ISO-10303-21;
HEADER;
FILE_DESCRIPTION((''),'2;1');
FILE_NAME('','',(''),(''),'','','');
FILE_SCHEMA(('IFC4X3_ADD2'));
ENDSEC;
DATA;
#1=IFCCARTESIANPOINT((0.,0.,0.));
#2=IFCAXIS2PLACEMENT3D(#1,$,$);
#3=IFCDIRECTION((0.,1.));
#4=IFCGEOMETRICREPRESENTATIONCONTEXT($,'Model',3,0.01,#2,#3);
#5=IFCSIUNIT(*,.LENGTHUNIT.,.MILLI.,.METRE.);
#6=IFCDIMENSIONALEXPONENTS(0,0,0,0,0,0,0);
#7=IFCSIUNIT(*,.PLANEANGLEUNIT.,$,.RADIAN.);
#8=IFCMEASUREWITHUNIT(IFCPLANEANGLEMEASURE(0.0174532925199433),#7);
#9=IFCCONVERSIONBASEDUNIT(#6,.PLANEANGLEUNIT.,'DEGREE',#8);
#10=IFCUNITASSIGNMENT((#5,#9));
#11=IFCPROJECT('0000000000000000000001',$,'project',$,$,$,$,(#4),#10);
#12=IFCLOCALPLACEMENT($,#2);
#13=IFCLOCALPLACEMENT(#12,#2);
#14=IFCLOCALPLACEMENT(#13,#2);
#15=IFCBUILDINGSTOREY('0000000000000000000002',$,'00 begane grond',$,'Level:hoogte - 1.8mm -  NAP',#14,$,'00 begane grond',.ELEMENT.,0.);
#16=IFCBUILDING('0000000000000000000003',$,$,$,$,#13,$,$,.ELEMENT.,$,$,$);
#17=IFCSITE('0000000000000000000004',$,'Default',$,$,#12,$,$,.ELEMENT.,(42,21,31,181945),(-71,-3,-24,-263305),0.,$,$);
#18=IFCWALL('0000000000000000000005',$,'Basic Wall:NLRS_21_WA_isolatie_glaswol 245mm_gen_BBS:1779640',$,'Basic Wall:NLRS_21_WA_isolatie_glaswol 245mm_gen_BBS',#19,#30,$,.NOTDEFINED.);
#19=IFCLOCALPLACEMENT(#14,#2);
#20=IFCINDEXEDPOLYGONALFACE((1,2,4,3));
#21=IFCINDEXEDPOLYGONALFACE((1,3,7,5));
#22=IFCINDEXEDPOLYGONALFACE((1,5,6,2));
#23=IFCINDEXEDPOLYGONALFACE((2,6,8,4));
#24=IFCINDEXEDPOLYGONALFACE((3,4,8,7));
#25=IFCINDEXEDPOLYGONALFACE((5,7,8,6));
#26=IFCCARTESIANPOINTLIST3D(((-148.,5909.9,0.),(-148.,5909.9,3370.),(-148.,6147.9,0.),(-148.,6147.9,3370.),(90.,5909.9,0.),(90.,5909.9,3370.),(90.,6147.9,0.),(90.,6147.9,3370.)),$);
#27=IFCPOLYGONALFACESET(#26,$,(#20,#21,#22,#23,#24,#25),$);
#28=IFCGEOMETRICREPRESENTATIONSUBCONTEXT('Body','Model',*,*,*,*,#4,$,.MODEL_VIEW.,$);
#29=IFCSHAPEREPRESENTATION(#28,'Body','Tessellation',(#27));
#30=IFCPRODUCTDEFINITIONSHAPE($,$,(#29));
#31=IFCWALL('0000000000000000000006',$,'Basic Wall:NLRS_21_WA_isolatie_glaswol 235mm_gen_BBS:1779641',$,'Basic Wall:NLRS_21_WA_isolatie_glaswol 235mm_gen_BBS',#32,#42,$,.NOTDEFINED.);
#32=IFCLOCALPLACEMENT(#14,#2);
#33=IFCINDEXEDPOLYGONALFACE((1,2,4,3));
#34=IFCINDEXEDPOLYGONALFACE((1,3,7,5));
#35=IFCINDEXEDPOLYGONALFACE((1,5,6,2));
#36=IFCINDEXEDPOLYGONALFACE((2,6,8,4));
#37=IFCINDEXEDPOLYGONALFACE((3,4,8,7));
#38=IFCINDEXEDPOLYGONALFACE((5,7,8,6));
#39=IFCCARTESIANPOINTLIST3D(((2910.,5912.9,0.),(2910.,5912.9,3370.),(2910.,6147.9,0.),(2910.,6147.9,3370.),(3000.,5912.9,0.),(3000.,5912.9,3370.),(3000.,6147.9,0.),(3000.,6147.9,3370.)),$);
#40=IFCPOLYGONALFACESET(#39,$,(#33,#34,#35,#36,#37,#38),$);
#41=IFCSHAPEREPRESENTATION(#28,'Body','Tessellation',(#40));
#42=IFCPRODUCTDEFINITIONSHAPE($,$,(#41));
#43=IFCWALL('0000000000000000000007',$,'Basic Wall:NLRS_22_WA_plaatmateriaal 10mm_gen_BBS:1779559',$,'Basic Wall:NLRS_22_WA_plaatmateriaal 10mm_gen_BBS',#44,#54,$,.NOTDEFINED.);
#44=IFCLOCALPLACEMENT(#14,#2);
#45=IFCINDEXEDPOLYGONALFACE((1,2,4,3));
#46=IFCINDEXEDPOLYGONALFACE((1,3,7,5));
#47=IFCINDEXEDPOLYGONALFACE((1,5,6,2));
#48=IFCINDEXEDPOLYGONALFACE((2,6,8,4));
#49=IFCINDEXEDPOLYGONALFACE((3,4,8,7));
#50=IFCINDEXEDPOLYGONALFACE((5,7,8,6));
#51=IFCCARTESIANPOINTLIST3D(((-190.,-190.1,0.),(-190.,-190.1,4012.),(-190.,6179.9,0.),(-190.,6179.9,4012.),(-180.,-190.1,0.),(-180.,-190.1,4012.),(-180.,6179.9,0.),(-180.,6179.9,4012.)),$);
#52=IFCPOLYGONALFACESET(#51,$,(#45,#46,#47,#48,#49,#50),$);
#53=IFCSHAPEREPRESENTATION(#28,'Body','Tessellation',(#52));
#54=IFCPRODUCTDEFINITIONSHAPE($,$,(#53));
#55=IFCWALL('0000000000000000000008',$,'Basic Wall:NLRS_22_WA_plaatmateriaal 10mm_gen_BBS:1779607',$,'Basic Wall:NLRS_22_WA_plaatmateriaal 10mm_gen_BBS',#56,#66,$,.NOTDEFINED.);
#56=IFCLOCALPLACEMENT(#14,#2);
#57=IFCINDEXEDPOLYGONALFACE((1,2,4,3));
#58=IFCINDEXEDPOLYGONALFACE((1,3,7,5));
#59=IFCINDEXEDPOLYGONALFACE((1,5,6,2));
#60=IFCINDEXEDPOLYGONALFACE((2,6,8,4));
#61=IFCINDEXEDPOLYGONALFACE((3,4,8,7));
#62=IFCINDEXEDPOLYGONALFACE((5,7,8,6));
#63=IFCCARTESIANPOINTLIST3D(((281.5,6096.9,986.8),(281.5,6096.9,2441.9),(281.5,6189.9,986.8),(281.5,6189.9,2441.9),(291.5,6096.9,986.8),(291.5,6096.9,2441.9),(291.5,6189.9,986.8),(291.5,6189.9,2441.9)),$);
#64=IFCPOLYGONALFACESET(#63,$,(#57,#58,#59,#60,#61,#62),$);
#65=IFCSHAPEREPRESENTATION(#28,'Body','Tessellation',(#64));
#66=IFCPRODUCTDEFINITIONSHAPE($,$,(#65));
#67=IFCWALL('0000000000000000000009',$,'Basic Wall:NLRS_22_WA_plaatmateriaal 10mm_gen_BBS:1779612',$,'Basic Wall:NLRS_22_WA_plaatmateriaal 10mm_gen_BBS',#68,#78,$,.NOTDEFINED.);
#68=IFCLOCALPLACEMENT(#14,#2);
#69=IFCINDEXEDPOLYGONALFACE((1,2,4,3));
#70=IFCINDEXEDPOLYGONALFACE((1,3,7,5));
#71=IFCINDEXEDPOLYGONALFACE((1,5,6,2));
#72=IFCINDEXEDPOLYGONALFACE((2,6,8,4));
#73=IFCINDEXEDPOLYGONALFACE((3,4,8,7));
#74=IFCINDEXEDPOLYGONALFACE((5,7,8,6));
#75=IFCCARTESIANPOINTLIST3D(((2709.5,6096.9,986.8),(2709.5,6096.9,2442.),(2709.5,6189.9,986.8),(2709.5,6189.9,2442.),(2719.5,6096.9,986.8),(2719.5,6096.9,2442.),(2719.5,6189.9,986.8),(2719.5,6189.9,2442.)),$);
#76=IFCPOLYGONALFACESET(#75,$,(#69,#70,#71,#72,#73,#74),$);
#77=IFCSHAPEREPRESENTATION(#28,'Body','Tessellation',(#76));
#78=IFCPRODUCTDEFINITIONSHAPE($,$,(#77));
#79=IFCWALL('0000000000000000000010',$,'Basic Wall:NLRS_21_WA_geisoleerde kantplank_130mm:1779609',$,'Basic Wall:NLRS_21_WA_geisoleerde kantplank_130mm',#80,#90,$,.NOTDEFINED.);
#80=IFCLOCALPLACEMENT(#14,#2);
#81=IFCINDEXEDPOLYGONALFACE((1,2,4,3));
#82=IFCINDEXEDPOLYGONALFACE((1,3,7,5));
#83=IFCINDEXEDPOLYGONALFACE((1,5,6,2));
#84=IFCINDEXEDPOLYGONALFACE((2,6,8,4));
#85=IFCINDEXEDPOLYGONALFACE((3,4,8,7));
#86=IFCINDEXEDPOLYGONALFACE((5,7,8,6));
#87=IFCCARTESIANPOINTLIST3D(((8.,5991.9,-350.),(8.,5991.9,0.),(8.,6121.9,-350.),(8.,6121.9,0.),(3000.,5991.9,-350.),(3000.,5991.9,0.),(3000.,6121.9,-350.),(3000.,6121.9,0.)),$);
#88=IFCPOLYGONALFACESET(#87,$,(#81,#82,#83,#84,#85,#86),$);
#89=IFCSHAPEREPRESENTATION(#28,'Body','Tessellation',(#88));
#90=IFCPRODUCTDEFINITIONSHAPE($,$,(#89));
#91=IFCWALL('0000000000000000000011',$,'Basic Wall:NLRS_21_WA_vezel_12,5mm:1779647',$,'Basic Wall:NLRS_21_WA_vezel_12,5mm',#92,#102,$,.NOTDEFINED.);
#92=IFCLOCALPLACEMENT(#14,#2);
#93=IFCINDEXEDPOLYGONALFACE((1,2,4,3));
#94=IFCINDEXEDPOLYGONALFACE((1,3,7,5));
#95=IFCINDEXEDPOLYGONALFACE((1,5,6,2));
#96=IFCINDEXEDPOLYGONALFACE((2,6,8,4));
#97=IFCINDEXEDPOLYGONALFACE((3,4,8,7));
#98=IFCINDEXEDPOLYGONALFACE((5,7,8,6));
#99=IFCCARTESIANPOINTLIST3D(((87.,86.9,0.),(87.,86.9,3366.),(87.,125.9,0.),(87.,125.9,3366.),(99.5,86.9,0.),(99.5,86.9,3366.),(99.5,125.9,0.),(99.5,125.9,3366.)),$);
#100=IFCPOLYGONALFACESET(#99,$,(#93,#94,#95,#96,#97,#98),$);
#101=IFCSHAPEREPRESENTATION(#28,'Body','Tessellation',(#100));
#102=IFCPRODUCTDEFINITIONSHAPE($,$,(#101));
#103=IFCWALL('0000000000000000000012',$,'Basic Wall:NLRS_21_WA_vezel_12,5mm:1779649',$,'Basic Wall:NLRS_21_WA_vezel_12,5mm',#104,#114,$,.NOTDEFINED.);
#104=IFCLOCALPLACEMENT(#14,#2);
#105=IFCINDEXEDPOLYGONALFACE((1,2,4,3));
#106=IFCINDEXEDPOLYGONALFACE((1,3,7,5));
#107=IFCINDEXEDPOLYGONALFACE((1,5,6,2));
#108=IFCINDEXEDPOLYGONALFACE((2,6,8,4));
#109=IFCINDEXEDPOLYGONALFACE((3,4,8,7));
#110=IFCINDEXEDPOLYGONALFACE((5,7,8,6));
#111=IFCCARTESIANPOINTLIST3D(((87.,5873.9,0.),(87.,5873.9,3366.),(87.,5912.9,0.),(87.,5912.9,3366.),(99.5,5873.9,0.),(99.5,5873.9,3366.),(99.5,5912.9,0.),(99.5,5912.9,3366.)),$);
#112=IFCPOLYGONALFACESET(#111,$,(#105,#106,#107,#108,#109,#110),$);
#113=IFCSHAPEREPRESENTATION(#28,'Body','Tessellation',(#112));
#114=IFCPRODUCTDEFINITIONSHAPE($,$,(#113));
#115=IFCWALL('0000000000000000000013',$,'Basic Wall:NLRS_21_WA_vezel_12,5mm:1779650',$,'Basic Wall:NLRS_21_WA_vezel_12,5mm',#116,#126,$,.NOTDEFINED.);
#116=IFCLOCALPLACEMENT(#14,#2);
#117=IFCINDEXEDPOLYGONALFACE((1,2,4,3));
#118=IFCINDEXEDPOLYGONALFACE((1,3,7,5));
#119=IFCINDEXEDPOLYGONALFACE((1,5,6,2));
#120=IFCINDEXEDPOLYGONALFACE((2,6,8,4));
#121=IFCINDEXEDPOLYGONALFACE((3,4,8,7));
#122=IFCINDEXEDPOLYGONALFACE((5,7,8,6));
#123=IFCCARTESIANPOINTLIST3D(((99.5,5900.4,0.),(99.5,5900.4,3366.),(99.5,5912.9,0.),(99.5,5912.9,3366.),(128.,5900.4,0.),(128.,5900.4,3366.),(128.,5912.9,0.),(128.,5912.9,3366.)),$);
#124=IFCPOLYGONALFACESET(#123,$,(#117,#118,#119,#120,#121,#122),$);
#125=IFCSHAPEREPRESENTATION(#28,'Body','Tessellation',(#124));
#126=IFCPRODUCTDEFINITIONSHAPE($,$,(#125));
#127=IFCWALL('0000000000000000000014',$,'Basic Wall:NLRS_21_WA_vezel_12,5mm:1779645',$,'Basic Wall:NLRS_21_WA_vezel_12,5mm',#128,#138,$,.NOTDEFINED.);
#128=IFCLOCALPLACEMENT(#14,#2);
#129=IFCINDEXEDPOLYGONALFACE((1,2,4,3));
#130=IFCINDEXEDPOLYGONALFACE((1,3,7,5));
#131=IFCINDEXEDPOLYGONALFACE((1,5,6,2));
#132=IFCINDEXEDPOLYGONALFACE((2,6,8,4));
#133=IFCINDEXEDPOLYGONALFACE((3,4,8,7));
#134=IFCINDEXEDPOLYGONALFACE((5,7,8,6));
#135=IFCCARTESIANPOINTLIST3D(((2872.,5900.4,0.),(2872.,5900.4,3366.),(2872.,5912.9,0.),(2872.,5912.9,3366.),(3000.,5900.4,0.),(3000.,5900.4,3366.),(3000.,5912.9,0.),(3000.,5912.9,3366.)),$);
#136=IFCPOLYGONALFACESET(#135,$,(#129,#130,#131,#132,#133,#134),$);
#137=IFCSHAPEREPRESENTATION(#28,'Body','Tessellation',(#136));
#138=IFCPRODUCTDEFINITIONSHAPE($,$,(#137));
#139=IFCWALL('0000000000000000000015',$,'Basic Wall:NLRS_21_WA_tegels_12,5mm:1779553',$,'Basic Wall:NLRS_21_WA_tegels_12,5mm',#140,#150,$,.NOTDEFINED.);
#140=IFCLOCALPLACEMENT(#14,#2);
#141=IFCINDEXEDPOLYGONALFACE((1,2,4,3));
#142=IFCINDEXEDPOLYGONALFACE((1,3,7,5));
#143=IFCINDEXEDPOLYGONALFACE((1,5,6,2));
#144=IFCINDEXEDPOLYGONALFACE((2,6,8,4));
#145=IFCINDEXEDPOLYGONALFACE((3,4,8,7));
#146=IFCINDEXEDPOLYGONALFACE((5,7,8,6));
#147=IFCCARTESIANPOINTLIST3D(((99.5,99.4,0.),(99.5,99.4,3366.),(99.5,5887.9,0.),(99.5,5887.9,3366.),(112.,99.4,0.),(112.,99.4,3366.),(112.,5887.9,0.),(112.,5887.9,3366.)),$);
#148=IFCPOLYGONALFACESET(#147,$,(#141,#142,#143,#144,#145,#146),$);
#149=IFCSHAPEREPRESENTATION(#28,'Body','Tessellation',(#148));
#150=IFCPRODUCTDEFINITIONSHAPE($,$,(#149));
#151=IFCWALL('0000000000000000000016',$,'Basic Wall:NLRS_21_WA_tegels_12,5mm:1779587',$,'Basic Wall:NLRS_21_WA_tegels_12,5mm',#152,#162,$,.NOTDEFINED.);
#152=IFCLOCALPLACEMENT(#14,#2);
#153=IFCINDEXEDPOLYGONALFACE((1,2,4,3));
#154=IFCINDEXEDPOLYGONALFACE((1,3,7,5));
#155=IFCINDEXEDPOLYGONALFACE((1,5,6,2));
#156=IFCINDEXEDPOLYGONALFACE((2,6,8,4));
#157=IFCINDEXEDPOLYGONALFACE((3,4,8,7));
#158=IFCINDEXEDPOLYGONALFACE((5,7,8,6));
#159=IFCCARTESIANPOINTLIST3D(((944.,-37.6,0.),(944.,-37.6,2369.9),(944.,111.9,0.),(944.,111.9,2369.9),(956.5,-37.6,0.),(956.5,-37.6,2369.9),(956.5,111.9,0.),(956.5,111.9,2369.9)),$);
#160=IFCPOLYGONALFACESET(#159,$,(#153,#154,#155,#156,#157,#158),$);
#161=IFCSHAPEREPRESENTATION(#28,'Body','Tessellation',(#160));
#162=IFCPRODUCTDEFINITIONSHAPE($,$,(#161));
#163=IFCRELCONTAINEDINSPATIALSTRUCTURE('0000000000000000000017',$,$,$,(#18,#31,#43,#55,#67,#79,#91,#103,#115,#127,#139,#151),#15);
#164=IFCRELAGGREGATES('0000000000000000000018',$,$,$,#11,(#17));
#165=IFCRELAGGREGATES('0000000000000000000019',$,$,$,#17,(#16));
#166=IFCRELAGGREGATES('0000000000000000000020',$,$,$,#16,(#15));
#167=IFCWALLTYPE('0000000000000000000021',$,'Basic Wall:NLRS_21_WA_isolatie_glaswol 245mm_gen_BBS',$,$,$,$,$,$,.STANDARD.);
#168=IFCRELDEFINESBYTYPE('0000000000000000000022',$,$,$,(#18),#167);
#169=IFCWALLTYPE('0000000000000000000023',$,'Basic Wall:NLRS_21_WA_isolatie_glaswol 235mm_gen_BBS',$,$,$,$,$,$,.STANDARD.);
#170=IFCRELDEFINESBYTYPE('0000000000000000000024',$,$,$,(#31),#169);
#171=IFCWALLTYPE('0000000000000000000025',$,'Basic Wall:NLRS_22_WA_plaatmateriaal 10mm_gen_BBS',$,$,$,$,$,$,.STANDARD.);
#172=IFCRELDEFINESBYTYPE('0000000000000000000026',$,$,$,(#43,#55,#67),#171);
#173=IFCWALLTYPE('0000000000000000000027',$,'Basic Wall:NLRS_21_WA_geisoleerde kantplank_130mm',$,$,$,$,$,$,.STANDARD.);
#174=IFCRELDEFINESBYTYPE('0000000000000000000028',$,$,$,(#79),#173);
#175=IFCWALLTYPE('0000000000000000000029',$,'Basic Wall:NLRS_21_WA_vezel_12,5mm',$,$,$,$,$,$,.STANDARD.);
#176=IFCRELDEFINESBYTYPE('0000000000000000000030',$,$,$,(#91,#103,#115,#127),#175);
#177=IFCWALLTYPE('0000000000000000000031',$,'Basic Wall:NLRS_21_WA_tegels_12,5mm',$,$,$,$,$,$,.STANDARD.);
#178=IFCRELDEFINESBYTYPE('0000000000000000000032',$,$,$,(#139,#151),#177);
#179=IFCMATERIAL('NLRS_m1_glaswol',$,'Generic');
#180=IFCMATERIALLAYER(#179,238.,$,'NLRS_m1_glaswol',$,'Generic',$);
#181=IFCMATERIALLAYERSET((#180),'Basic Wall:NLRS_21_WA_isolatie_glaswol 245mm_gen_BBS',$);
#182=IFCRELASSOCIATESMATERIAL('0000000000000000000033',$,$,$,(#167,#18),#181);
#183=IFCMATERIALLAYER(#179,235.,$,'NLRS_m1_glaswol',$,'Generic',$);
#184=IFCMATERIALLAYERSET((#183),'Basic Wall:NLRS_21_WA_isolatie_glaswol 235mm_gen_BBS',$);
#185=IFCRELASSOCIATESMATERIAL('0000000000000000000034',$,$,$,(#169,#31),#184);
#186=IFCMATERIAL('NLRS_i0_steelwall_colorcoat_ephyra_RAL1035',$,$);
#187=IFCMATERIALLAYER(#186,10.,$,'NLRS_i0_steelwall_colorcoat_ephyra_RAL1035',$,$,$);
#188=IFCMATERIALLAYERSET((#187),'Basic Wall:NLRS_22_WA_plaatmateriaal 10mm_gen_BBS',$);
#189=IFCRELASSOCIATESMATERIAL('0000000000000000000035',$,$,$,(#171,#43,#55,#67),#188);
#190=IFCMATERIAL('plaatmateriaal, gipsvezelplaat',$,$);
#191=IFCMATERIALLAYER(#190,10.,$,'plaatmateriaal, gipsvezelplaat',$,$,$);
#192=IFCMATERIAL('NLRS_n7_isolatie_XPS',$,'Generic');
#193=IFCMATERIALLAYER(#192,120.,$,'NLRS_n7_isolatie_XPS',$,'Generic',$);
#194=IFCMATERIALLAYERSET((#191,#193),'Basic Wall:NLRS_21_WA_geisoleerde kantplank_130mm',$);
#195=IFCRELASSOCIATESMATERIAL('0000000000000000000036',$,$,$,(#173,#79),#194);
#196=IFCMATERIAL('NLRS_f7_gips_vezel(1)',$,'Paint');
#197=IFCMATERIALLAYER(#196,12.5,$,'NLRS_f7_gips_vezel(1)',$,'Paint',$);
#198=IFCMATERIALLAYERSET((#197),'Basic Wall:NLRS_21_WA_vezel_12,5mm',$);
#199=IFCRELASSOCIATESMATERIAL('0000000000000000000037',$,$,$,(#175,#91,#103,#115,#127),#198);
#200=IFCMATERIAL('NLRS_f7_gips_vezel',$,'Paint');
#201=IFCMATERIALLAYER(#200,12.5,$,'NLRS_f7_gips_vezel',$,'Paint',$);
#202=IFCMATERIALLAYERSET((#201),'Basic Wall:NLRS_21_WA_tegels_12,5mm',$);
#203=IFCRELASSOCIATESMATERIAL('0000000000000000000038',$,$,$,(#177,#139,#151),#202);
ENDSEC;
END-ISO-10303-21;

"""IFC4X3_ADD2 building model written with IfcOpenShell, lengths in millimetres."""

from ifc_helpers import new_model, entity, si_unit, converted_unit, direction, frame, frame_2d, origin, place, context, subcontext, project, spatial, rectangle, extrude, material, layer, layer_set, layer_usage, type_object, element, save


model = new_model("IFC4X3_ADD2")

# Units and contexts
model_context = context("Model", 3, precision=0.01, world=origin(), true_north=direction((0.0, 1.0)))
body_context = subcontext(model_context, "Body", "Model", "MODEL_VIEW")
ifc_project = project(units=[si_unit("LENGTHUNIT", "METRE", prefix="MILLI"), converted_unit("PLANEANGLEUNIT", "DEGREE", entity("IfcPlaneAngleMeasure", 0.0174532925199433), si_unit("PLANEANGLEUNIT", "RADIAN"), dimensions=[0, 0, 0, 0, 0, 0, 0])], contexts=[model_context])

# Site, building, storey
site_placement = place(None, origin())
site = spatial("IfcSite", under=ifc_project, at=site_placement, Name="Default", CompositionType="ELEMENT", RefLatitude=(42, 21, 31, 181945), RefLongitude=(-71, -3, -24, -263305), RefElevation=0.0)
building_placement = place(site_placement, origin())
building = spatial("IfcBuilding", under=site, at=building_placement, CompositionType="ELEMENT")
storey_placement = place(building_placement, origin())
storey = spatial("IfcBuildingStorey", under=building, at=storey_placement, Name="00 begane grond", ObjectType="Level:hoogte - 1.8mm -  NAP", LongName="00 begane grond", CompositionType="ELEMENT", Elevation=0.0)

# Walls
ifc_material_1 = material(Name="NLRS_m1_glaswol", Category="Generic")
ifc_layer_1 = layer(ifc_material_1, 238.0, Name="NLRS_m1_glaswol", Category="Generic")
ifc_layer_set_1 = layer_set([ifc_layer_1], Name="Basic Wall:NLRS_21_WA_isolatie_glaswol 245mm_gen_BBS")
ifc_layer_usage_1 = layer_usage(ifc_layer_set_1, "AXIS2", "NEGATIVE", 119.0)
wall_type_1 = type_object("IfcWallType", Name="Basic Wall:NLRS_21_WA_isolatie_glaswol 245mm_gen_BBS", PredefinedType="STANDARD", material=ifc_layer_set_1)
wall_1_placement = place(storey_placement, frame((-29.0, 6147.9, 0.0), z_axis=(0.0, 0.0, 1.0), x_axis=(0.0, -1.0, 0.0)))
element("IfcWall", 1, at=wall_1_placement, inside=storey, type_object=wall_type_1, material=ifc_layer_usage_1, Name="Basic Wall:NLRS_21_WA_isolatie_glaswol 245mm_gen_BBS:1779640", ObjectType="Basic Wall:NLRS_21_WA_isolatie_glaswol 245mm_gen_BBS", PredefinedType="NOTDEFINED", context=body_context, shape_type="SweptSolid", body=[
    extrude(rectangle(XDim=238.0, YDim=238.0, at=frame_2d((119.0, 0.0), x_axis=(-1.0, 0.0))), origin(), (0.0, 0.0, 1.0), 3370.0),
])
ifc_layer_2 = layer(ifc_material_1, 235.0, Name="NLRS_m1_glaswol", Category="Generic")
ifc_layer_set_2 = layer_set([ifc_layer_2], Name="Basic Wall:NLRS_21_WA_isolatie_glaswol 235mm_gen_BBS")
ifc_layer_usage_2 = layer_usage(ifc_layer_set_2, "AXIS2", "NEGATIVE", 117.5)
wall_type_2 = type_object("IfcWallType", Name="Basic Wall:NLRS_21_WA_isolatie_glaswol 235mm_gen_BBS", PredefinedType="STANDARD", material=ifc_layer_set_2)
wall_2_placement = place(storey_placement, frame((2910.0, 6030.4, 0.0)))
element("IfcWall", 2, at=wall_2_placement, inside=storey, type_object=wall_type_2, material=ifc_layer_usage_2, Name="Basic Wall:NLRS_21_WA_isolatie_glaswol 235mm_gen_BBS:1779641", ObjectType="Basic Wall:NLRS_21_WA_isolatie_glaswol 235mm_gen_BBS", PredefinedType="NOTDEFINED", context=body_context, shape_type="SweptSolid", body=[
    extrude(rectangle(XDim=90.0, YDim=235.0, at=frame_2d((45.0, 0.0), x_axis=(-1.0, 0.0))), origin(), (0.0, 0.0, 1.0), 3370.0),
])
ifc_material_2 = material(Name="NLRS_i0_steelwall_colorcoat_ephyra_RAL1035")
ifc_layer_3 = layer(ifc_material_2, 10.0, Name="NLRS_i0_steelwall_colorcoat_ephyra_RAL1035")
ifc_layer_set_3 = layer_set([ifc_layer_3], Name="Basic Wall:NLRS_22_WA_plaatmateriaal 10mm_gen_BBS")
ifc_layer_usage_3 = layer_usage(ifc_layer_set_3, "AXIS2", "POSITIVE", -5.0)
wall_type_3 = type_object("IfcWallType", Name="Basic Wall:NLRS_22_WA_plaatmateriaal 10mm_gen_BBS", PredefinedType="STANDARD", material=ifc_layer_set_3)
wall_3_placement = place(storey_placement, frame((-185.0, 6179.9, 0.0), z_axis=(0.0, 0.0, 1.0), x_axis=(0.0, -1.0, 0.0)))
element("IfcWall", 3, at=wall_3_placement, inside=storey, type_object=wall_type_3, material=ifc_layer_usage_3, Name="Basic Wall:NLRS_22_WA_plaatmateriaal 10mm_gen_BBS:1779559", ObjectType="Basic Wall:NLRS_22_WA_plaatmateriaal 10mm_gen_BBS", PredefinedType="NOTDEFINED", context=body_context, shape_type="SweptSolid", body=[
    extrude(rectangle(XDim=6370.0, YDim=10.0, at=frame_2d((3185.0, 0.0), x_axis=(-1.0, 0.0))), origin(), (0.0, 0.0, 1.0), 4012.0),
])
ifc_layer_usage_4 = layer_usage(ifc_layer_set_3, "AXIS2", "POSITIVE", -5.0)
wall_4_placement = place(storey_placement, frame((286.5, 6096.9, 986.8), z_axis=(0.0, 0.0, 1.0), x_axis=(0.0, 1.0, 0.0)))
element("IfcWall", 4, at=wall_4_placement, inside=storey, type_object=wall_type_3, material=ifc_layer_usage_4, Name="Basic Wall:NLRS_22_WA_plaatmateriaal 10mm_gen_BBS:1779607", ObjectType="Basic Wall:NLRS_22_WA_plaatmateriaal 10mm_gen_BBS", PredefinedType="NOTDEFINED", context=body_context, shape_type="SweptSolid", body=[
    extrude(rectangle(XDim=93.0, YDim=10.0, at=frame_2d((46.5, 0.0), x_axis=(-1.0, 0.0))), origin(), (0.0, 0.0, 1.0), 1455.1),
])
ifc_layer_usage_5 = layer_usage(ifc_layer_set_3, "AXIS2", "NEGATIVE", 5.0)
wall_5_placement = place(storey_placement, frame((2714.5, 6096.9, 986.8), z_axis=(0.0, 0.0, 1.0), x_axis=(0.0, 1.0, 0.0)))
element("IfcWall", 5, at=wall_5_placement, inside=storey, type_object=wall_type_3, material=ifc_layer_usage_5, Name="Basic Wall:NLRS_22_WA_plaatmateriaal 10mm_gen_BBS:1779612", ObjectType="Basic Wall:NLRS_22_WA_plaatmateriaal 10mm_gen_BBS", PredefinedType="NOTDEFINED", context=body_context, shape_type="SweptSolid", body=[
    extrude(rectangle(XDim=93.0, YDim=10.0, at=frame_2d((46.5, 0.0), x_axis=(-1.0, 0.0))), origin(), (0.0, 0.0, 1.0), 1455.2),
])
ifc_material_3 = material(Name="plaatmateriaal, gipsvezelplaat")
ifc_layer_4 = layer(ifc_material_3, 10.0, Name="plaatmateriaal, gipsvezelplaat")
ifc_material_4 = material(Name="NLRS_n7_isolatie_XPS", Category="Generic")
ifc_layer_5 = layer(ifc_material_4, 120.0, Name="NLRS_n7_isolatie_XPS", Category="Generic")
ifc_layer_set_4 = layer_set([ifc_layer_4, ifc_layer_5], Name="Basic Wall:NLRS_21_WA_geisoleerde kantplank_130mm")
ifc_layer_usage_6 = layer_usage(ifc_layer_set_4, "AXIS2", "NEGATIVE", 65.0)
wall_type_4 = type_object("IfcWallType", Name="Basic Wall:NLRS_21_WA_geisoleerde kantplank_130mm", PredefinedType="STANDARD", material=ifc_layer_set_4)
wall_6_placement = place(storey_placement, frame((8.0, 6056.9, -350.0)))
element("IfcWall", 6, at=wall_6_placement, inside=storey, type_object=wall_type_4, material=ifc_layer_usage_6, Name="Basic Wall:NLRS_21_WA_geisoleerde kantplank_130mm:1779609", ObjectType="Basic Wall:NLRS_21_WA_geisoleerde kantplank_130mm", PredefinedType="NOTDEFINED", context=body_context, shape_type="SweptSolid", body=[
    extrude(rectangle(XDim=2992.0, YDim=130.0, at=frame_2d((1496.0, 0.0), x_axis=(-1.0, 0.0))), origin(), (0.0, 0.0, 1.0), 350.0),
])
ifc_material_5 = material(Name="NLRS_f7_gips_vezel(1)", Category="Paint")
ifc_layer_6 = layer(ifc_material_5, 12.5, Name="NLRS_f7_gips_vezel(1)", Category="Paint")
ifc_layer_set_5 = layer_set([ifc_layer_6], Name="Basic Wall:NLRS_21_WA_vezel_12,5mm")
ifc_layer_usage_7 = layer_usage(ifc_layer_set_5, "AXIS2", "NEGATIVE", 6.2)
wall_type_5 = type_object("IfcWallType", Name="Basic Wall:NLRS_21_WA_vezel_12,5mm", PredefinedType="STANDARD", material=ifc_layer_set_5)
wall_7_placement = place(storey_placement, frame((93.2, 125.9, 0.0), z_axis=(0.0, 0.0, 1.0), x_axis=(0.0, -1.0, 0.0)))
element("IfcWall", 7, at=wall_7_placement, inside=storey, type_object=wall_type_5, material=ifc_layer_usage_7, Name="Basic Wall:NLRS_21_WA_vezel_12,5mm:1779647", ObjectType="Basic Wall:NLRS_21_WA_vezel_12,5mm", PredefinedType="NOTDEFINED", context=body_context, shape_type="SweptSolid", body=[
    extrude(rectangle(XDim=39.0, YDim=12.5, at=frame_2d((19.5, 0.0), x_axis=(-1.0, 0.0))), origin(), (0.0, 0.0, 1.0), 3366.0),
])
ifc_layer_usage_8 = layer_usage(ifc_layer_set_5, "AXIS2", "POSITIVE", -6.2)
wall_8_placement = place(storey_placement, frame((93.2, 5873.9, 0.0), z_axis=(0.0, 0.0, 1.0), x_axis=(0.0, 1.0, 0.0)))
element("IfcWall", 8, at=wall_8_placement, inside=storey, type_object=wall_type_5, material=ifc_layer_usage_8, Name="Basic Wall:NLRS_21_WA_vezel_12,5mm:1779649", ObjectType="Basic Wall:NLRS_21_WA_vezel_12,5mm", PredefinedType="NOTDEFINED", context=body_context, shape_type="SweptSolid", body=[
    extrude(rectangle(XDim=39.0, YDim=12.5, at=frame_2d((19.5, 0.0), x_axis=(-1.0, 0.0))), origin(), (0.0, 0.0, 1.0), 3366.0),
])
ifc_layer_usage_9 = layer_usage(ifc_layer_set_5, "AXIS2", "POSITIVE", -6.2)
wall_9_placement = place(storey_placement, frame((99.5, 5906.7, 0.0)))
element("IfcWall", 9, at=wall_9_placement, inside=storey, type_object=wall_type_5, material=ifc_layer_usage_9, Name="Basic Wall:NLRS_21_WA_vezel_12,5mm:1779650", ObjectType="Basic Wall:NLRS_21_WA_vezel_12,5mm", PredefinedType="NOTDEFINED", context=body_context, shape_type="SweptSolid", body=[
    extrude(rectangle(XDim=28.5, YDim=12.5, at=frame_2d((14.2, 0.0), x_axis=(-1.0, 0.0))), origin(), (0.0, 0.0, 1.0), 3366.0),
])
ifc_layer_usage_10 = layer_usage(ifc_layer_set_5, "AXIS2", "NEGATIVE", 6.2)
wall_10_placement = place(storey_placement, frame((2872.0, 5906.7, 0.0)))
element("IfcWall", 10, at=wall_10_placement, inside=storey, type_object=wall_type_5, material=ifc_layer_usage_10, Name="Basic Wall:NLRS_21_WA_vezel_12,5mm:1779645", ObjectType="Basic Wall:NLRS_21_WA_vezel_12,5mm", PredefinedType="NOTDEFINED", context=body_context, shape_type="SweptSolid", body=[
    extrude(rectangle(XDim=128.0, YDim=12.5, at=frame_2d((64.0, 0.0), x_axis=(-1.0, 0.0))), origin(), (0.0, 0.0, 1.0), 3366.0),
])
ifc_material_6 = material(Name="NLRS_f7_gips_vezel", Category="Paint")
ifc_layer_7 = layer(ifc_material_6, 12.5, Name="NLRS_f7_gips_vezel", Category="Paint")
ifc_layer_set_6 = layer_set([ifc_layer_7], Name="Basic Wall:NLRS_21_WA_tegels_12,5mm")
ifc_layer_usage_11 = layer_usage(ifc_layer_set_6, "AXIS2", "NEGATIVE", 6.2)
wall_type_6 = type_object("IfcWallType", Name="Basic Wall:NLRS_21_WA_tegels_12,5mm", PredefinedType="STANDARD", material=ifc_layer_set_6)
wall_11_placement = place(storey_placement, frame((105.7, 5887.9, 0.0), z_axis=(0.0, 0.0, 1.0), x_axis=(0.0, -1.0, 0.0)))
element("IfcWall", 11, at=wall_11_placement, inside=storey, type_object=wall_type_6, material=ifc_layer_usage_11, Name="Basic Wall:NLRS_21_WA_tegels_12,5mm:1779553", ObjectType="Basic Wall:NLRS_21_WA_tegels_12,5mm", PredefinedType="NOTDEFINED", context=body_context, shape_type="SweptSolid", body=[
    extrude(rectangle(XDim=5788.5, YDim=12.5, at=frame_2d((2894.3, 0.0), x_axis=(-1.0, 0.0))), origin(), (0.0, 0.0, 1.0), 3366.0),
])
ifc_layer_usage_12 = layer_usage(ifc_layer_set_6, "AXIS2", "NEGATIVE", 6.2)
wall_12_placement = place(storey_placement, frame((950.2, 111.9, 0.0), z_axis=(0.0, 0.0, 1.0), x_axis=(0.0, -1.0, 0.0)))
element("IfcWall", 12, at=wall_12_placement, inside=storey, type_object=wall_type_6, material=ifc_layer_usage_12, Name="Basic Wall:NLRS_21_WA_tegels_12,5mm:1779587", ObjectType="Basic Wall:NLRS_21_WA_tegels_12,5mm", PredefinedType="NOTDEFINED", context=body_context, shape_type="SweptSolid", body=[
    extrude(rectangle(XDim=149.5, YDim=12.5, at=frame_2d((74.8, 0.0), x_axis=(-1.0, 0.0))), origin(), (0.0, 0.0, 1.0), 2369.9),
])

save(model, "model.ifc")
